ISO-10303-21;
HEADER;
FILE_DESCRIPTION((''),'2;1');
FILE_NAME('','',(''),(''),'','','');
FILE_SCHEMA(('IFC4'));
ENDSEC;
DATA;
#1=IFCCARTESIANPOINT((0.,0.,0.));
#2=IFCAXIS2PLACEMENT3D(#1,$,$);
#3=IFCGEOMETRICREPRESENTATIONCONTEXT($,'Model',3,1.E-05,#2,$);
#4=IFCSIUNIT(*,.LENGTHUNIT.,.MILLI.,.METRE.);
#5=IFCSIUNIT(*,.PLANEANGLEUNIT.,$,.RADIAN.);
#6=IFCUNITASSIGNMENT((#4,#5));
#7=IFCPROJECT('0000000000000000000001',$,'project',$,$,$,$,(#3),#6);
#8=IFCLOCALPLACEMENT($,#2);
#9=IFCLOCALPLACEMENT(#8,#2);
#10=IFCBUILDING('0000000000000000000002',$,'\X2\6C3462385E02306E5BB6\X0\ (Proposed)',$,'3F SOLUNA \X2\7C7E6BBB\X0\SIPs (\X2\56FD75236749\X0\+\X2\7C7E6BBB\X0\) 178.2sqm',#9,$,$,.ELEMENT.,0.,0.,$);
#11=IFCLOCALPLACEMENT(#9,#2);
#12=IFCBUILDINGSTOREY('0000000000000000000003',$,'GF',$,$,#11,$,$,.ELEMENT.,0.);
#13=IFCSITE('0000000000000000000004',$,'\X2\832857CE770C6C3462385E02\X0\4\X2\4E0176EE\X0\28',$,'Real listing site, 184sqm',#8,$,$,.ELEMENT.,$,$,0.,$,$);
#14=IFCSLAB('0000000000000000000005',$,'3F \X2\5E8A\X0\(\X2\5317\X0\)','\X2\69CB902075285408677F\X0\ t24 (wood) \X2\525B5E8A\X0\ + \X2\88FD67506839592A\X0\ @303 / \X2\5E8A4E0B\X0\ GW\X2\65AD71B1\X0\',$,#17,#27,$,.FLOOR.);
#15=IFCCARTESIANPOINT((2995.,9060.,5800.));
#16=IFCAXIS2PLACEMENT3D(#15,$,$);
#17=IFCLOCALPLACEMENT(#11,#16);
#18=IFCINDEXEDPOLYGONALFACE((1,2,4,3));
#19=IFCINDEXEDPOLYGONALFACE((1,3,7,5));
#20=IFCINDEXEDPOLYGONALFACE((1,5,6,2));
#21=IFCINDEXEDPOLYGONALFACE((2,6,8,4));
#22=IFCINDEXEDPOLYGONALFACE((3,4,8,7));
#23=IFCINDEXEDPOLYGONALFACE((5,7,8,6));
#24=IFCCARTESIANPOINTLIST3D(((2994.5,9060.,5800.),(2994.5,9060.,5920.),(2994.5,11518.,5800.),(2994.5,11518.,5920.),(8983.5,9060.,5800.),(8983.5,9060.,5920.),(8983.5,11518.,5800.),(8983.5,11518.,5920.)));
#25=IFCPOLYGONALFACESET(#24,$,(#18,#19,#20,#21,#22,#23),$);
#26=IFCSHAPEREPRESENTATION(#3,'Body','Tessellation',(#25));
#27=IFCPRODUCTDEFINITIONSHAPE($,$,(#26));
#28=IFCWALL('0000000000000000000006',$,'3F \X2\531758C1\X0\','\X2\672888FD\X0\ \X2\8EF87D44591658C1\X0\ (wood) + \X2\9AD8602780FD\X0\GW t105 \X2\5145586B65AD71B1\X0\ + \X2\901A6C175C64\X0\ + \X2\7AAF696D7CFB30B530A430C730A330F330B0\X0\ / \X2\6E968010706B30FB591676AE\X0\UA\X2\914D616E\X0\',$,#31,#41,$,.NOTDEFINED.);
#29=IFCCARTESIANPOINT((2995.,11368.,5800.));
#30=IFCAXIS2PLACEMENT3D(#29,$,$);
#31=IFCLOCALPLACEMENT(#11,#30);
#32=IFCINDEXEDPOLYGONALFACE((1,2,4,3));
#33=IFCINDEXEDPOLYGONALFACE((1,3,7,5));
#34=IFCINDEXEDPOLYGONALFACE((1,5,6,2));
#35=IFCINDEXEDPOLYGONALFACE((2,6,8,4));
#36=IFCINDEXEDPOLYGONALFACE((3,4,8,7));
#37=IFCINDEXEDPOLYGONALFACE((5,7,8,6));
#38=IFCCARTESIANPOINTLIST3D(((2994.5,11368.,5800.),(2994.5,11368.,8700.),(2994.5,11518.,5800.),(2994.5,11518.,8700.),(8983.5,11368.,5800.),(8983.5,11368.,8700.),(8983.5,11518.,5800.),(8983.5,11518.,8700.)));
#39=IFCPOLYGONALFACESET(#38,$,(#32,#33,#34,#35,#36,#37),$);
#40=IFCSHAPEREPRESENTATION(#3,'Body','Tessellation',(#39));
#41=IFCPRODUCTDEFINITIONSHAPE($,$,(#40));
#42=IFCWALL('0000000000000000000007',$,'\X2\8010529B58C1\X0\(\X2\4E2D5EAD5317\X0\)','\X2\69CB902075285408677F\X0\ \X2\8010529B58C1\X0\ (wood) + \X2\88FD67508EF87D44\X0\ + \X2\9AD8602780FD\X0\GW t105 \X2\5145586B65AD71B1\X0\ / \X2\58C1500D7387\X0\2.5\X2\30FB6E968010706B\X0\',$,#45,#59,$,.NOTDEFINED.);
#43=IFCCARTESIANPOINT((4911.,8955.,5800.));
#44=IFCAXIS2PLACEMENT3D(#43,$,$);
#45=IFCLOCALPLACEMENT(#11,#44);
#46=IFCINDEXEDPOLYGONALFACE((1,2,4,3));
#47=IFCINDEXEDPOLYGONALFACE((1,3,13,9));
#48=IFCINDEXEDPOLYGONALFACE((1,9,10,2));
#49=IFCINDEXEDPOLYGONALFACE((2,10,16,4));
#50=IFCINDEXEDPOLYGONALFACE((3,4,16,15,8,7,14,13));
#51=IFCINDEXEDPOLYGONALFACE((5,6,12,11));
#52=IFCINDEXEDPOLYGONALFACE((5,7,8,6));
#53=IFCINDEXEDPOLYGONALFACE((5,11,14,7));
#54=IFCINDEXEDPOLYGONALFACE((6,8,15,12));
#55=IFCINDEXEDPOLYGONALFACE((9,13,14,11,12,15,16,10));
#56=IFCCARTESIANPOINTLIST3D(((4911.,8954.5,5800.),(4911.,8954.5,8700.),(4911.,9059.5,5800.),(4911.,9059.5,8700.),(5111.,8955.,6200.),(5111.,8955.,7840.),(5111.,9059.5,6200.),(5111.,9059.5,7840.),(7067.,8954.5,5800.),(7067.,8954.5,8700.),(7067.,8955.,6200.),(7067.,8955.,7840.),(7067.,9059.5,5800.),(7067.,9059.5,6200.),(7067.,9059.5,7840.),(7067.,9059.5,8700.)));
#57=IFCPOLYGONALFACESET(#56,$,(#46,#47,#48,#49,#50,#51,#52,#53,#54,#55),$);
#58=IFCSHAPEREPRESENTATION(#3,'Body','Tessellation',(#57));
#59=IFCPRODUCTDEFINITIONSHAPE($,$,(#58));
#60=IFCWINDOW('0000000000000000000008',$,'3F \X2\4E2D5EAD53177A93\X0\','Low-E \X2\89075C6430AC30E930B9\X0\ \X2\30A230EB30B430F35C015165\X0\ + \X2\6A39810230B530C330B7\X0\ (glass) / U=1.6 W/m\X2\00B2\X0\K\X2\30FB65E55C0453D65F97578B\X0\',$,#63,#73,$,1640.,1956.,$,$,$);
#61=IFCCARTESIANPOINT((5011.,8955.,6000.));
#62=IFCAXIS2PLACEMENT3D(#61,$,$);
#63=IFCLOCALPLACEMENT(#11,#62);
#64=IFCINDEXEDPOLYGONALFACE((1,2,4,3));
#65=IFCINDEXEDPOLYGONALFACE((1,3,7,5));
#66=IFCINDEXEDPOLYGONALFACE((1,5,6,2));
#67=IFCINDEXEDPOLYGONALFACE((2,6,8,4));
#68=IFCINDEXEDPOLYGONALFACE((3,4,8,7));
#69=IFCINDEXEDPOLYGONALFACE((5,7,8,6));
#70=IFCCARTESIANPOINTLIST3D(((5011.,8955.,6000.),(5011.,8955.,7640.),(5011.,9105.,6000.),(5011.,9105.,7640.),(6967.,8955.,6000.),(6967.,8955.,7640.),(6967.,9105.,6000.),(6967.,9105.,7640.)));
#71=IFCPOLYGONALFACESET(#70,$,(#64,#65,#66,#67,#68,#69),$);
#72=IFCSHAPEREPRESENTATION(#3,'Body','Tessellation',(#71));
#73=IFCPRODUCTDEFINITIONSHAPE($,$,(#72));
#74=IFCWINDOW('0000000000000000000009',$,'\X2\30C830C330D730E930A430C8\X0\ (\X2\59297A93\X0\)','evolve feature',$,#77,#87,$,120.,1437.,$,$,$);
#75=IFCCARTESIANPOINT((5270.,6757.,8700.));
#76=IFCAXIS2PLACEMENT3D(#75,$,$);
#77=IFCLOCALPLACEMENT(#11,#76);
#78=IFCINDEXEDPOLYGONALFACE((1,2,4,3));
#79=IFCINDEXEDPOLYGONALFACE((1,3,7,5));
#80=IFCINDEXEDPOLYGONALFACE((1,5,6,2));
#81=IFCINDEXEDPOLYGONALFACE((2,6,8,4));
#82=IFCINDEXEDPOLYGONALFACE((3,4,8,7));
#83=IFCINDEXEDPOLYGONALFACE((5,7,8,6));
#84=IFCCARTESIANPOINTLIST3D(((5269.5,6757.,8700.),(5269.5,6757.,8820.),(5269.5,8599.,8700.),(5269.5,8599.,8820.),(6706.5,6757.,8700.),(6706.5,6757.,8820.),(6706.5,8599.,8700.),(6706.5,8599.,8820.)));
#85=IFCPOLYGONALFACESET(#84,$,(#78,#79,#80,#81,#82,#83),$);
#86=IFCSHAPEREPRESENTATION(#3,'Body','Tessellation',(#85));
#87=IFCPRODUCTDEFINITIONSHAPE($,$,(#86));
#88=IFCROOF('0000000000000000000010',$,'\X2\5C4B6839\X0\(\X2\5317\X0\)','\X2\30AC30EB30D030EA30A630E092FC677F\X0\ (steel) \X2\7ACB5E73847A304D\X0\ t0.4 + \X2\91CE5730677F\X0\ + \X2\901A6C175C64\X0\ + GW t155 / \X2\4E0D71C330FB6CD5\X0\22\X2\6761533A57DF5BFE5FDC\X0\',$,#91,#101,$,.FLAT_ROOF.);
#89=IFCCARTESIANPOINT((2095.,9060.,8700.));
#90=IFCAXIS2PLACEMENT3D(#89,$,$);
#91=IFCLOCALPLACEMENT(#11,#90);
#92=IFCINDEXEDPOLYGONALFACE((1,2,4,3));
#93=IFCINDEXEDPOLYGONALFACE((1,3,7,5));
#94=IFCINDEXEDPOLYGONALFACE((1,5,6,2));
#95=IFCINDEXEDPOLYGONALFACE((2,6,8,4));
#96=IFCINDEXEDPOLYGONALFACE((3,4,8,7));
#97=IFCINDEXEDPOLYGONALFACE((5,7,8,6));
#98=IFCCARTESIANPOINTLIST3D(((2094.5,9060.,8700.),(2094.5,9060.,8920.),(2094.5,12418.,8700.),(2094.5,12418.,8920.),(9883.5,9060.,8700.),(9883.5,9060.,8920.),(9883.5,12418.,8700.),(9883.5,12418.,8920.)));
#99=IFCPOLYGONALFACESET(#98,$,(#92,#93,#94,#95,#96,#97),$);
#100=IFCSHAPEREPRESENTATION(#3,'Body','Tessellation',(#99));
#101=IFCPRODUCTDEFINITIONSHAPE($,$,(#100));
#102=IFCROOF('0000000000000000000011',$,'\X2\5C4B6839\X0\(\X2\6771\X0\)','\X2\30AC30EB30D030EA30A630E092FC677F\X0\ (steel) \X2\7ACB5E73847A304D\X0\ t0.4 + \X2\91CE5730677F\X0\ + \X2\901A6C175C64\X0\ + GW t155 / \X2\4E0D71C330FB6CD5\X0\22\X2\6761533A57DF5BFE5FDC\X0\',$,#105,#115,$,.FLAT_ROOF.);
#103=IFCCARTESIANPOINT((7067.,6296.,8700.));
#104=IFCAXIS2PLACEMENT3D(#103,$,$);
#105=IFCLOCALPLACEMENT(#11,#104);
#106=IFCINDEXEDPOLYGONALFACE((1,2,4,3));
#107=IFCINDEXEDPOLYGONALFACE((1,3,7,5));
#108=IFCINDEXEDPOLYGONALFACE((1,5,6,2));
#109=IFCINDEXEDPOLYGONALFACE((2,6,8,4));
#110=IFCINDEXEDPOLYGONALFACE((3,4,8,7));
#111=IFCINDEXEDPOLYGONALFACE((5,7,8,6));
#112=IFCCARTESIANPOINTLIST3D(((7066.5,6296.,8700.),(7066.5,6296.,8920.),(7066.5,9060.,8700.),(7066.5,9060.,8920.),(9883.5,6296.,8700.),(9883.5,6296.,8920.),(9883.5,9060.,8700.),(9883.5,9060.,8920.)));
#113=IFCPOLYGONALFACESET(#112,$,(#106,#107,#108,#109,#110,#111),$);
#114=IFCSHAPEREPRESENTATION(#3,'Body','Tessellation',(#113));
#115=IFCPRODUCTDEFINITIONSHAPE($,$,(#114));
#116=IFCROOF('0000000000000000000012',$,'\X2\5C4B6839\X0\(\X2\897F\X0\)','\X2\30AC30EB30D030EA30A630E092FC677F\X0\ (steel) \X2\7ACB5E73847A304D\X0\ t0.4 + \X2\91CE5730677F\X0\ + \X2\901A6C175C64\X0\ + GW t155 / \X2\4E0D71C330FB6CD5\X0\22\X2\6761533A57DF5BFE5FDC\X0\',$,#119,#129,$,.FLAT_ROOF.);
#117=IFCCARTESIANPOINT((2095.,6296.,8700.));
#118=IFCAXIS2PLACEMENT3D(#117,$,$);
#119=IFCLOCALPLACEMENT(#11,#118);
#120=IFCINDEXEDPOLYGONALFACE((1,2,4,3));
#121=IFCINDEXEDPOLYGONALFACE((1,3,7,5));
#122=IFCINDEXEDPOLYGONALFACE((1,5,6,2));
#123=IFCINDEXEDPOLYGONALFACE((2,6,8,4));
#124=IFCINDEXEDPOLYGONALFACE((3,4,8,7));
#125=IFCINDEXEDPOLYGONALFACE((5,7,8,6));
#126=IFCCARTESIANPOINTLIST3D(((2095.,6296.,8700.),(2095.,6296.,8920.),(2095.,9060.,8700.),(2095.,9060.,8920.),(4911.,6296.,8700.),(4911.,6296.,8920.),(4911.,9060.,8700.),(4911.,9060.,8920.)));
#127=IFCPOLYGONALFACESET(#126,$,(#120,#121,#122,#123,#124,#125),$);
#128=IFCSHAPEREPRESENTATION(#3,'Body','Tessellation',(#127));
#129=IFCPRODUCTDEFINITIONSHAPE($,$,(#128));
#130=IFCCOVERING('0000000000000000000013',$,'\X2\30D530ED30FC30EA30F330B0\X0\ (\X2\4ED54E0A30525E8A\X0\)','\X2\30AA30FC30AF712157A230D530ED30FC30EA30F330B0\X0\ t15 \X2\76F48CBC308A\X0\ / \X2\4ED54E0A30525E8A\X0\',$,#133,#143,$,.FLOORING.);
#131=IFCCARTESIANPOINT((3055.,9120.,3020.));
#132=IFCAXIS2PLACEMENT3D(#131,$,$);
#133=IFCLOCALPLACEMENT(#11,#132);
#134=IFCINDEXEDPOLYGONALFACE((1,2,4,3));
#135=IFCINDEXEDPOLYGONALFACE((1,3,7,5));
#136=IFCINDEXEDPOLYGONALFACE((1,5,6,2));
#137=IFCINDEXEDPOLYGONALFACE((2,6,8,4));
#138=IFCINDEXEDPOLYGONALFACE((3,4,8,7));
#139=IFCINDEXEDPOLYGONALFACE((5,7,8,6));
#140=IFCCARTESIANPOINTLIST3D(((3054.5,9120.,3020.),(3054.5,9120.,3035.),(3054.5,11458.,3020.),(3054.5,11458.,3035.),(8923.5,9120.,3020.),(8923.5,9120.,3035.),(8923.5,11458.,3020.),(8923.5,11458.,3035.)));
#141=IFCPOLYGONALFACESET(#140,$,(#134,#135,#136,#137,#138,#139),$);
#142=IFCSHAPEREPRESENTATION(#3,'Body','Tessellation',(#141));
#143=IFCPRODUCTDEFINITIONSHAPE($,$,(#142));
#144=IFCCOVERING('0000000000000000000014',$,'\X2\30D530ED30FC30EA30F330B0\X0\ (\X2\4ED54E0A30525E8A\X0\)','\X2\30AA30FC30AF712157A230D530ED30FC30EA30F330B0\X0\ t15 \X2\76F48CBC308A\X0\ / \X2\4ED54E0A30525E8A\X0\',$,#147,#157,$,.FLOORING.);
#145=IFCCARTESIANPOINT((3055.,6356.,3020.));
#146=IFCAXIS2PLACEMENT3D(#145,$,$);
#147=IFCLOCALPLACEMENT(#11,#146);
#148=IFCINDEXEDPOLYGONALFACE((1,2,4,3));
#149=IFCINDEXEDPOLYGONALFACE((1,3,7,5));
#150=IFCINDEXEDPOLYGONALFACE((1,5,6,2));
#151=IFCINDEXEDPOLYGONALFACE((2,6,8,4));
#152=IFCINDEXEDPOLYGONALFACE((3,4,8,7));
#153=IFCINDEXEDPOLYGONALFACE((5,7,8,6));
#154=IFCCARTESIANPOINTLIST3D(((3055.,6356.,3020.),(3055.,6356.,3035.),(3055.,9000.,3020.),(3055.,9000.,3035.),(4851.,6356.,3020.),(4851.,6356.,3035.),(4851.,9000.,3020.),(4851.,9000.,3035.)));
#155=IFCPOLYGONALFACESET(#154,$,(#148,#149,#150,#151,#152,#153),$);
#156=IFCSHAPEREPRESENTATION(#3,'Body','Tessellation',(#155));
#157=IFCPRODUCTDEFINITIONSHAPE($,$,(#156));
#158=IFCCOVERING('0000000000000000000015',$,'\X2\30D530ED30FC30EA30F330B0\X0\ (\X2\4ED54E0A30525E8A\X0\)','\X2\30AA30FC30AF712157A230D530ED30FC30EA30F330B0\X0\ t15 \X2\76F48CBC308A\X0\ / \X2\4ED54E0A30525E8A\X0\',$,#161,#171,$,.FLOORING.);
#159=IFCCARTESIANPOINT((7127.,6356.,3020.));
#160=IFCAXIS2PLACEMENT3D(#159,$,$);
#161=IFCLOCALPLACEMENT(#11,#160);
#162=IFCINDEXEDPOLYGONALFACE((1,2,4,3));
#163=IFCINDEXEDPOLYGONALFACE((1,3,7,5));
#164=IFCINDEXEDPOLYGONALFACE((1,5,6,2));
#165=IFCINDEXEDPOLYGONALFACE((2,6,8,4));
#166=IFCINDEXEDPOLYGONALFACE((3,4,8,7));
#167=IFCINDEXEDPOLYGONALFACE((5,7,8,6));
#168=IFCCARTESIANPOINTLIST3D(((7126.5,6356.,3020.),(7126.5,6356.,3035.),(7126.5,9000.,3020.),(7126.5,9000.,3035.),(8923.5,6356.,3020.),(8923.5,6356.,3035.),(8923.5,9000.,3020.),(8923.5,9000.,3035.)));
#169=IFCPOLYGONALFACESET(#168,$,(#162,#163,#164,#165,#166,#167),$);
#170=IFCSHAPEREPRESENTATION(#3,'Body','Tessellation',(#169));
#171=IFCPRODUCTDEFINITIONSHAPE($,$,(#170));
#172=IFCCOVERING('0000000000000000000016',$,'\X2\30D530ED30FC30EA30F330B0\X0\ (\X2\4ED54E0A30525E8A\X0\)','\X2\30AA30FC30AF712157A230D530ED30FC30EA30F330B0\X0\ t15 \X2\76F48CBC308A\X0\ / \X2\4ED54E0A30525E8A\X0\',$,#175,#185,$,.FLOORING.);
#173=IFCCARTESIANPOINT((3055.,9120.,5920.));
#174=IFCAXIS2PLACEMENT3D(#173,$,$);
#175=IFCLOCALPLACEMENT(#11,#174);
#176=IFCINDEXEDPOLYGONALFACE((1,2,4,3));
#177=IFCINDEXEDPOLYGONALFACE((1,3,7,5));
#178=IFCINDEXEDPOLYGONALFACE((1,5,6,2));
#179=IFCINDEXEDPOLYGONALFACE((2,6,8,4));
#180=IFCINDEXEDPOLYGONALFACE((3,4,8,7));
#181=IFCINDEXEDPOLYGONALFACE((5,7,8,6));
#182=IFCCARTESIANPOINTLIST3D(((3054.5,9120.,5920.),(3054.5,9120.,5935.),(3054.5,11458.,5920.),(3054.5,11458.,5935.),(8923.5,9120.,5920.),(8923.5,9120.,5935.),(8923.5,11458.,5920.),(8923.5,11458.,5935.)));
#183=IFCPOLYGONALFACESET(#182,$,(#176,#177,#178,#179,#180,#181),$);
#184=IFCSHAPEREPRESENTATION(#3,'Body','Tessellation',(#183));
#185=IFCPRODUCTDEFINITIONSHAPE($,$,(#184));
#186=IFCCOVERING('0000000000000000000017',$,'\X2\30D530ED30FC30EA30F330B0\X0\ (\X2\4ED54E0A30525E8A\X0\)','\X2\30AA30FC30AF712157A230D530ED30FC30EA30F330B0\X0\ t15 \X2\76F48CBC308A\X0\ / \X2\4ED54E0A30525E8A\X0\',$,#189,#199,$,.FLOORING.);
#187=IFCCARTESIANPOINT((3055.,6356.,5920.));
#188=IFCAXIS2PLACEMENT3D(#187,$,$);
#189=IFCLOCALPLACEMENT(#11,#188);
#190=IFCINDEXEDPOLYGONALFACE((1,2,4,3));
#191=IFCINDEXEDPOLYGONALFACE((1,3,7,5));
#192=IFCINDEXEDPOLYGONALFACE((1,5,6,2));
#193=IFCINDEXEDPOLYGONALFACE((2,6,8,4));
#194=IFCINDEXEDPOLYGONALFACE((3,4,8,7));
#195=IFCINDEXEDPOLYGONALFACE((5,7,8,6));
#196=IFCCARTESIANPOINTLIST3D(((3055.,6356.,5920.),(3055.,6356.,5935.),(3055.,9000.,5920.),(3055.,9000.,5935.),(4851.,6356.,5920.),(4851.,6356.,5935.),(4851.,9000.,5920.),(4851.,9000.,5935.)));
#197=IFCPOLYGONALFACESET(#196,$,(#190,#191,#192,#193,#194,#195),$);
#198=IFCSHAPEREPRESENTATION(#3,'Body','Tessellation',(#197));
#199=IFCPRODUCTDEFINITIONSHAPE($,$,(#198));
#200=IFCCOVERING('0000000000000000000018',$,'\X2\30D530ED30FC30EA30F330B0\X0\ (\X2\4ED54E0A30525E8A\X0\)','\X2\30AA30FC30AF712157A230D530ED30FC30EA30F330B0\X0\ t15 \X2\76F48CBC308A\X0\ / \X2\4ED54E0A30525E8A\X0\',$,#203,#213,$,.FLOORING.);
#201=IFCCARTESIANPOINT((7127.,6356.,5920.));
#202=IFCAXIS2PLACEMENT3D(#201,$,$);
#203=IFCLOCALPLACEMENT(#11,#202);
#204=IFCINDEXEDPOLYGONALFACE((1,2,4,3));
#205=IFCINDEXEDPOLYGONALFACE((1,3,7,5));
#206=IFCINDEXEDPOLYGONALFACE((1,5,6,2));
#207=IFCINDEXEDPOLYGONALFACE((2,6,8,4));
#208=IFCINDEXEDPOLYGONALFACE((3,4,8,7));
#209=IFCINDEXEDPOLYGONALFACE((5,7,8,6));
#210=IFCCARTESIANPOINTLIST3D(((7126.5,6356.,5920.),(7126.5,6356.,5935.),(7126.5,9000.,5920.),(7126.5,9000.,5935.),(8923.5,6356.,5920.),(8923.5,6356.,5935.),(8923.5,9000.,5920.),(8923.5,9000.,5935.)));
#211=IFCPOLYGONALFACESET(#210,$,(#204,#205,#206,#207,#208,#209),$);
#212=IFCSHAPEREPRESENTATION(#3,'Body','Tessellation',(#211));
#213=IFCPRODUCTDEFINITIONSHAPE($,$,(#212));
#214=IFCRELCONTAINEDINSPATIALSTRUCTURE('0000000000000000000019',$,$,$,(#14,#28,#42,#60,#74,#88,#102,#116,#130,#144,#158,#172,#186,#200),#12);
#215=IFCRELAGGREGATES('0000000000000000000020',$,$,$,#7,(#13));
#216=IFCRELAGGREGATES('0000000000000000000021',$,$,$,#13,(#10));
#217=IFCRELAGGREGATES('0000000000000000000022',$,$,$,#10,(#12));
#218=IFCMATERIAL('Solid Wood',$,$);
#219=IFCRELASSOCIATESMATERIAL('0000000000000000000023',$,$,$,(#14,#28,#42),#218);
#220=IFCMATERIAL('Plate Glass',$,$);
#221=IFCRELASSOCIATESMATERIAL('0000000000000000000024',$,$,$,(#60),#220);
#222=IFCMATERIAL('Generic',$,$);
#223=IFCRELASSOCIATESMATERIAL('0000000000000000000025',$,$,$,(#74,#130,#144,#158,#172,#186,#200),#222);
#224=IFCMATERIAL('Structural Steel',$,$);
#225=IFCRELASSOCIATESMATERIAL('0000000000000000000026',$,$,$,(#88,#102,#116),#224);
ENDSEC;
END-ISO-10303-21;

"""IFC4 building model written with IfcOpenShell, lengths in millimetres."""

from ifc_helpers import new_model, si_unit, frame, frame_2d, origin, place, context, project, spatial, rectangle, extrude, material, element, fill, save


model = new_model("IFC4")

# Units and contexts
model_context = context("Model", 3, precision=1e-05, world=origin())
ifc_project = project(units=[si_unit("LENGTHUNIT", "METRE", prefix="MILLI"), si_unit("PLANEANGLEUNIT", "RADIAN")], contexts=[model_context])

# Site, building, storey
site_placement = place(None, origin())
site = spatial("IfcSite", under=ifc_project, at=site_placement, Name="茨城県水戸市4丁目28", ObjectType="Real listing site, 184sqm", CompositionType="ELEMENT", RefElevation=0.0)
building_placement = place(site_placement, origin())
building = spatial("IfcBuilding", under=site, at=building_placement, Name="水戸市の家 (Proposed)", ObjectType="3F SOLUNA 籾殻SIPs (国産杉+籾殻) 178.2sqm", CompositionType="ELEMENT", ElevationOfRefHeight=0.0, ElevationOfTerrain=0.0)
storey_placement = place(building_placement, origin())
storey = spatial("IfcBuildingStorey", under=building, at=storey_placement, Name="GF", CompositionType="ELEMENT", Elevation=0.0)

# Slab
ifc_material_1 = material(Name="Solid Wood")
slab_placement = place(storey_placement, frame((2995.0, 9060.0, 5800.0)))
element("IfcSlab", 1, at=slab_placement, inside=storey, material=ifc_material_1, Name="3F 床(北)", Description="構造用合板 t24 (wood) 剛床 + 製材根太 @303 / 床下 GW断熱", PredefinedType="FLOOR", context=model_context, shape_type="SweptSolid", body=[
    extrude(rectangle(XDim=5989.0, YDim=2458.0, at=frame_2d((2994.0, 1229.0))), frame((2995.0, 9060.0, 5800.0)), (0.0, 0.0, 1.0), 120.0),
])

# Wall
wall_1_placement = place(storey_placement, frame((2995.0, 11368.0, 5800.0)))
element("IfcWall", 2, at=wall_1_placement, inside=storey, material=ifc_material_1, Name="3F 北壁", Description="木製 軸組外壁 (wood) + 高性能GW t105 充填断熱 + 通気層 + 窯業系サイディング / 準耐火・外皮UA配慮", PredefinedType="NOTDEFINED", context=model_context, shape_type="SweptSolid", body=[
    extrude(rectangle(XDim=5989.0, YDim=150.0, at=frame_2d((2994.0, 75.0))), frame((2995.0, 11368.0, 5800.0)), (0.0, 0.0, 1.0), 2900.0),
])

# Wall, opening, window
wall_2_placement = place(storey_placement, frame((4911.0, 8955.0, 5800.0)))
wall_2 = element("IfcWall", 3, at=wall_2_placement, inside=storey, material=ifc_material_1, Name="耐力壁(中庭北)", Description="構造用合板 耐力壁 (wood) + 製材軸組 + 高性能GW t105 充填断熱 / 壁倍率2.5・準耐火", PredefinedType="NOTDEFINED", context=model_context, shape_type="SweptSolid", body=[
    extrude(rectangle(XDim=2156.0, YDim=105.0, at=frame_2d((1078.0, 52.0))), frame((4911.0, 8955.0, 5800.0)), (0.0, 0.0, 1.0), 2900.0),
])
opening_placement = place(storey_placement, frame((5011.0, 8955.0, 6000.0)))
opening = element("IfcOpeningElement", 4, at=opening_placement, cuts=wall_2, PredefinedType="NOTDEFINED", context=model_context, shape_type="SweptSolid", body=[
    extrude(rectangle(XDim=1956.0, YDim=150.0, at=frame_2d((978.0, 75.0))), frame((5011.0, 8955.0, 6000.0)), (0.0, 0.0, 1.0), 1640.0),
])
ifc_material_2 = material(Name="Plate Glass")
window_1_placement = place(storey_placement, frame((5011.0, 8955.0, 6000.0)))
window_1 = element("IfcWindow", 5, at=window_1_placement, inside=storey, material=ifc_material_2, Name="3F 中庭北窓", Description="Low-E 複層ガラス アルゴン封入 + 樹脂サッシ (glass) / U=1.6 W/m²K・日射取得型", OverallHeight=1640.0, OverallWidth=1956.0, context=model_context, shape_type="SweptSolid", body=[
    extrude(rectangle(XDim=1956.0, YDim=150.0, at=frame_2d((978.0, 75.0))), frame((5011.0, 8955.0, 6000.0)), (0.0, 0.0, 1.0), 1640.0),
])
fill(opening, window_1)

# Window
ifc_material_3 = material(Name="Generic")
window_2_placement = place(storey_placement, frame((5270.0, 6757.0, 8700.0)))
element("IfcWindow", 6, at=window_2_placement, inside=storey, material=ifc_material_3, Name="トップライト (天窓)", Description="evolve feature", OverallHeight=120.0, OverallWidth=1437.0, context=model_context, shape_type="SweptSolid", body=[
    extrude(rectangle(XDim=1437.0, YDim=1842.0, at=frame_2d((718.0, 921.0))), frame((5270.0, 6757.0, 8700.0)), (0.0, 0.0, 1.0), 120.0),
])

# Roofs
ifc_material_4 = material(Name="Structural Steel")
roof_1_placement = place(storey_placement, frame((2095.0, 9060.0, 8700.0)))
element("IfcRoof", 7, at=roof_1_placement, inside=storey, material=ifc_material_4, Name="屋根(北)", Description="ガルバリウム鋼板 (steel) 立平葺き t0.4 + 野地板 + 通気層 + GW t155 / 不燃・法22条区域対応", PredefinedType="FLAT_ROOF", context=model_context, shape_type="SweptSolid", body=[
    extrude(rectangle(XDim=7789.0, YDim=3358.0, at=frame_2d((3894.0, 1679.0))), frame((2095.0, 9060.0, 8700.0)), (0.0, 0.0, 1.0), 220.0),
])
roof_2_placement = place(storey_placement, frame((7067.0, 6296.0, 8700.0)))
element("IfcRoof", 8, at=roof_2_placement, inside=storey, material=ifc_material_4, Name="屋根(東)", Description="ガルバリウム鋼板 (steel) 立平葺き t0.4 + 野地板 + 通気層 + GW t155 / 不燃・法22条区域対応", PredefinedType="FLAT_ROOF", context=model_context, shape_type="SweptSolid", body=[
    extrude(rectangle(XDim=2817.0, YDim=2764.0, at=frame_2d((1408.0, 1382.0))), frame((7067.0, 6296.0, 8700.0)), (0.0, 0.0, 1.0), 220.0),
])
roof_3_placement = place(storey_placement, frame((2095.0, 6296.0, 8700.0)))
element("IfcRoof", 9, at=roof_3_placement, inside=storey, material=ifc_material_4, Name="屋根(西)", Description="ガルバリウム鋼板 (steel) 立平葺き t0.4 + 野地板 + 通気層 + GW t155 / 不燃・法22条区域対応", PredefinedType="FLAT_ROOF", context=model_context, shape_type="SweptSolid", body=[
    extrude(rectangle(XDim=2816.0, YDim=2764.0, at=frame_2d((1408.0, 1382.0))), frame((2095.0, 6296.0, 8700.0)), (0.0, 0.0, 1.0), 220.0),
])

# Coverings
covering_1_placement = place(storey_placement, frame((3055.0, 9120.0, 3020.0)))
element("IfcCovering", 10, at=covering_1_placement, inside=storey, material=ifc_material_3, Name="フローリング (仕上げ床)", Description="オーク無垢フローリング t15 直貼り / 仕上げ床", PredefinedType="FLOORING", context=model_context, shape_type="SweptSolid", body=[
    extrude(rectangle(XDim=5869.0, YDim=2338.0, at=frame_2d((2934.0, 1169.0))), frame((3055.0, 9120.0, 3020.0)), (0.0, 0.0, 1.0), 15.0),
])
covering_2_placement = place(storey_placement, frame((3055.0, 6356.0, 3020.0)))
element("IfcCovering", 11, at=covering_2_placement, inside=storey, material=ifc_material_3, Name="フローリング (仕上げ床)", Description="オーク無垢フローリング t15 直貼り / 仕上げ床", PredefinedType="FLOORING", context=model_context, shape_type="SweptSolid", body=[
    extrude(rectangle(XDim=1796.0, YDim=2644.0, at=frame_2d((898.0, 1322.0))), frame((3055.0, 6356.0, 3020.0)), (0.0, 0.0, 1.0), 15.0),
])
covering_3_placement = place(storey_placement, frame((7127.0, 6356.0, 3020.0)))
element("IfcCovering", 12, at=covering_3_placement, inside=storey, material=ifc_material_3, Name="フローリング (仕上げ床)", Description="オーク無垢フローリング t15 直貼り / 仕上げ床", PredefinedType="FLOORING", context=model_context, shape_type="SweptSolid", body=[
    extrude(rectangle(XDim=1797.0, YDim=2644.0, at=frame_2d((898.0, 1322.0))), frame((7127.0, 6356.0, 3020.0)), (0.0, 0.0, 1.0), 15.0),
])
covering_4_placement = place(storey_placement, frame((3055.0, 9120.0, 5920.0)))
element("IfcCovering", 13, at=covering_4_placement, inside=storey, material=ifc_material_3, Name="フローリング (仕上げ床)", Description="オーク無垢フローリング t15 直貼り / 仕上げ床", PredefinedType="FLOORING", context=model_context, shape_type="SweptSolid", body=[
    extrude(rectangle(XDim=5869.0, YDim=2338.0, at=frame_2d((2934.0, 1169.0))), frame((3055.0, 9120.0, 5920.0)), (0.0, 0.0, 1.0), 15.0),
])
covering_5_placement = place(storey_placement, frame((3055.0, 6356.0, 5920.0)))
element("IfcCovering", 14, at=covering_5_placement, inside=storey, material=ifc_material_3, Name="フローリング (仕上げ床)", Description="オーク無垢フローリング t15 直貼り / 仕上げ床", PredefinedType="FLOORING", context=model_context, shape_type="SweptSolid", body=[
    extrude(rectangle(XDim=1796.0, YDim=2644.0, at=frame_2d((898.0, 1322.0))), frame((3055.0, 6356.0, 5920.0)), (0.0, 0.0, 1.0), 15.0),
])
covering_6_placement = place(storey_placement, frame((7127.0, 6356.0, 5920.0)))
element("IfcCovering", 15, at=covering_6_placement, inside=storey, material=ifc_material_3, Name="フローリング (仕上げ床)", Description="オーク無垢フローリング t15 直貼り / 仕上げ床", PredefinedType="FLOORING", context=model_context, shape_type="SweptSolid", body=[
    extrude(rectangle(XDim=1797.0, YDim=2644.0, at=frame_2d((898.0, 1322.0))), frame((7127.0, 6356.0, 5920.0)), (0.0, 0.0, 1.0), 15.0),
])

save(model, "model.ifc")
